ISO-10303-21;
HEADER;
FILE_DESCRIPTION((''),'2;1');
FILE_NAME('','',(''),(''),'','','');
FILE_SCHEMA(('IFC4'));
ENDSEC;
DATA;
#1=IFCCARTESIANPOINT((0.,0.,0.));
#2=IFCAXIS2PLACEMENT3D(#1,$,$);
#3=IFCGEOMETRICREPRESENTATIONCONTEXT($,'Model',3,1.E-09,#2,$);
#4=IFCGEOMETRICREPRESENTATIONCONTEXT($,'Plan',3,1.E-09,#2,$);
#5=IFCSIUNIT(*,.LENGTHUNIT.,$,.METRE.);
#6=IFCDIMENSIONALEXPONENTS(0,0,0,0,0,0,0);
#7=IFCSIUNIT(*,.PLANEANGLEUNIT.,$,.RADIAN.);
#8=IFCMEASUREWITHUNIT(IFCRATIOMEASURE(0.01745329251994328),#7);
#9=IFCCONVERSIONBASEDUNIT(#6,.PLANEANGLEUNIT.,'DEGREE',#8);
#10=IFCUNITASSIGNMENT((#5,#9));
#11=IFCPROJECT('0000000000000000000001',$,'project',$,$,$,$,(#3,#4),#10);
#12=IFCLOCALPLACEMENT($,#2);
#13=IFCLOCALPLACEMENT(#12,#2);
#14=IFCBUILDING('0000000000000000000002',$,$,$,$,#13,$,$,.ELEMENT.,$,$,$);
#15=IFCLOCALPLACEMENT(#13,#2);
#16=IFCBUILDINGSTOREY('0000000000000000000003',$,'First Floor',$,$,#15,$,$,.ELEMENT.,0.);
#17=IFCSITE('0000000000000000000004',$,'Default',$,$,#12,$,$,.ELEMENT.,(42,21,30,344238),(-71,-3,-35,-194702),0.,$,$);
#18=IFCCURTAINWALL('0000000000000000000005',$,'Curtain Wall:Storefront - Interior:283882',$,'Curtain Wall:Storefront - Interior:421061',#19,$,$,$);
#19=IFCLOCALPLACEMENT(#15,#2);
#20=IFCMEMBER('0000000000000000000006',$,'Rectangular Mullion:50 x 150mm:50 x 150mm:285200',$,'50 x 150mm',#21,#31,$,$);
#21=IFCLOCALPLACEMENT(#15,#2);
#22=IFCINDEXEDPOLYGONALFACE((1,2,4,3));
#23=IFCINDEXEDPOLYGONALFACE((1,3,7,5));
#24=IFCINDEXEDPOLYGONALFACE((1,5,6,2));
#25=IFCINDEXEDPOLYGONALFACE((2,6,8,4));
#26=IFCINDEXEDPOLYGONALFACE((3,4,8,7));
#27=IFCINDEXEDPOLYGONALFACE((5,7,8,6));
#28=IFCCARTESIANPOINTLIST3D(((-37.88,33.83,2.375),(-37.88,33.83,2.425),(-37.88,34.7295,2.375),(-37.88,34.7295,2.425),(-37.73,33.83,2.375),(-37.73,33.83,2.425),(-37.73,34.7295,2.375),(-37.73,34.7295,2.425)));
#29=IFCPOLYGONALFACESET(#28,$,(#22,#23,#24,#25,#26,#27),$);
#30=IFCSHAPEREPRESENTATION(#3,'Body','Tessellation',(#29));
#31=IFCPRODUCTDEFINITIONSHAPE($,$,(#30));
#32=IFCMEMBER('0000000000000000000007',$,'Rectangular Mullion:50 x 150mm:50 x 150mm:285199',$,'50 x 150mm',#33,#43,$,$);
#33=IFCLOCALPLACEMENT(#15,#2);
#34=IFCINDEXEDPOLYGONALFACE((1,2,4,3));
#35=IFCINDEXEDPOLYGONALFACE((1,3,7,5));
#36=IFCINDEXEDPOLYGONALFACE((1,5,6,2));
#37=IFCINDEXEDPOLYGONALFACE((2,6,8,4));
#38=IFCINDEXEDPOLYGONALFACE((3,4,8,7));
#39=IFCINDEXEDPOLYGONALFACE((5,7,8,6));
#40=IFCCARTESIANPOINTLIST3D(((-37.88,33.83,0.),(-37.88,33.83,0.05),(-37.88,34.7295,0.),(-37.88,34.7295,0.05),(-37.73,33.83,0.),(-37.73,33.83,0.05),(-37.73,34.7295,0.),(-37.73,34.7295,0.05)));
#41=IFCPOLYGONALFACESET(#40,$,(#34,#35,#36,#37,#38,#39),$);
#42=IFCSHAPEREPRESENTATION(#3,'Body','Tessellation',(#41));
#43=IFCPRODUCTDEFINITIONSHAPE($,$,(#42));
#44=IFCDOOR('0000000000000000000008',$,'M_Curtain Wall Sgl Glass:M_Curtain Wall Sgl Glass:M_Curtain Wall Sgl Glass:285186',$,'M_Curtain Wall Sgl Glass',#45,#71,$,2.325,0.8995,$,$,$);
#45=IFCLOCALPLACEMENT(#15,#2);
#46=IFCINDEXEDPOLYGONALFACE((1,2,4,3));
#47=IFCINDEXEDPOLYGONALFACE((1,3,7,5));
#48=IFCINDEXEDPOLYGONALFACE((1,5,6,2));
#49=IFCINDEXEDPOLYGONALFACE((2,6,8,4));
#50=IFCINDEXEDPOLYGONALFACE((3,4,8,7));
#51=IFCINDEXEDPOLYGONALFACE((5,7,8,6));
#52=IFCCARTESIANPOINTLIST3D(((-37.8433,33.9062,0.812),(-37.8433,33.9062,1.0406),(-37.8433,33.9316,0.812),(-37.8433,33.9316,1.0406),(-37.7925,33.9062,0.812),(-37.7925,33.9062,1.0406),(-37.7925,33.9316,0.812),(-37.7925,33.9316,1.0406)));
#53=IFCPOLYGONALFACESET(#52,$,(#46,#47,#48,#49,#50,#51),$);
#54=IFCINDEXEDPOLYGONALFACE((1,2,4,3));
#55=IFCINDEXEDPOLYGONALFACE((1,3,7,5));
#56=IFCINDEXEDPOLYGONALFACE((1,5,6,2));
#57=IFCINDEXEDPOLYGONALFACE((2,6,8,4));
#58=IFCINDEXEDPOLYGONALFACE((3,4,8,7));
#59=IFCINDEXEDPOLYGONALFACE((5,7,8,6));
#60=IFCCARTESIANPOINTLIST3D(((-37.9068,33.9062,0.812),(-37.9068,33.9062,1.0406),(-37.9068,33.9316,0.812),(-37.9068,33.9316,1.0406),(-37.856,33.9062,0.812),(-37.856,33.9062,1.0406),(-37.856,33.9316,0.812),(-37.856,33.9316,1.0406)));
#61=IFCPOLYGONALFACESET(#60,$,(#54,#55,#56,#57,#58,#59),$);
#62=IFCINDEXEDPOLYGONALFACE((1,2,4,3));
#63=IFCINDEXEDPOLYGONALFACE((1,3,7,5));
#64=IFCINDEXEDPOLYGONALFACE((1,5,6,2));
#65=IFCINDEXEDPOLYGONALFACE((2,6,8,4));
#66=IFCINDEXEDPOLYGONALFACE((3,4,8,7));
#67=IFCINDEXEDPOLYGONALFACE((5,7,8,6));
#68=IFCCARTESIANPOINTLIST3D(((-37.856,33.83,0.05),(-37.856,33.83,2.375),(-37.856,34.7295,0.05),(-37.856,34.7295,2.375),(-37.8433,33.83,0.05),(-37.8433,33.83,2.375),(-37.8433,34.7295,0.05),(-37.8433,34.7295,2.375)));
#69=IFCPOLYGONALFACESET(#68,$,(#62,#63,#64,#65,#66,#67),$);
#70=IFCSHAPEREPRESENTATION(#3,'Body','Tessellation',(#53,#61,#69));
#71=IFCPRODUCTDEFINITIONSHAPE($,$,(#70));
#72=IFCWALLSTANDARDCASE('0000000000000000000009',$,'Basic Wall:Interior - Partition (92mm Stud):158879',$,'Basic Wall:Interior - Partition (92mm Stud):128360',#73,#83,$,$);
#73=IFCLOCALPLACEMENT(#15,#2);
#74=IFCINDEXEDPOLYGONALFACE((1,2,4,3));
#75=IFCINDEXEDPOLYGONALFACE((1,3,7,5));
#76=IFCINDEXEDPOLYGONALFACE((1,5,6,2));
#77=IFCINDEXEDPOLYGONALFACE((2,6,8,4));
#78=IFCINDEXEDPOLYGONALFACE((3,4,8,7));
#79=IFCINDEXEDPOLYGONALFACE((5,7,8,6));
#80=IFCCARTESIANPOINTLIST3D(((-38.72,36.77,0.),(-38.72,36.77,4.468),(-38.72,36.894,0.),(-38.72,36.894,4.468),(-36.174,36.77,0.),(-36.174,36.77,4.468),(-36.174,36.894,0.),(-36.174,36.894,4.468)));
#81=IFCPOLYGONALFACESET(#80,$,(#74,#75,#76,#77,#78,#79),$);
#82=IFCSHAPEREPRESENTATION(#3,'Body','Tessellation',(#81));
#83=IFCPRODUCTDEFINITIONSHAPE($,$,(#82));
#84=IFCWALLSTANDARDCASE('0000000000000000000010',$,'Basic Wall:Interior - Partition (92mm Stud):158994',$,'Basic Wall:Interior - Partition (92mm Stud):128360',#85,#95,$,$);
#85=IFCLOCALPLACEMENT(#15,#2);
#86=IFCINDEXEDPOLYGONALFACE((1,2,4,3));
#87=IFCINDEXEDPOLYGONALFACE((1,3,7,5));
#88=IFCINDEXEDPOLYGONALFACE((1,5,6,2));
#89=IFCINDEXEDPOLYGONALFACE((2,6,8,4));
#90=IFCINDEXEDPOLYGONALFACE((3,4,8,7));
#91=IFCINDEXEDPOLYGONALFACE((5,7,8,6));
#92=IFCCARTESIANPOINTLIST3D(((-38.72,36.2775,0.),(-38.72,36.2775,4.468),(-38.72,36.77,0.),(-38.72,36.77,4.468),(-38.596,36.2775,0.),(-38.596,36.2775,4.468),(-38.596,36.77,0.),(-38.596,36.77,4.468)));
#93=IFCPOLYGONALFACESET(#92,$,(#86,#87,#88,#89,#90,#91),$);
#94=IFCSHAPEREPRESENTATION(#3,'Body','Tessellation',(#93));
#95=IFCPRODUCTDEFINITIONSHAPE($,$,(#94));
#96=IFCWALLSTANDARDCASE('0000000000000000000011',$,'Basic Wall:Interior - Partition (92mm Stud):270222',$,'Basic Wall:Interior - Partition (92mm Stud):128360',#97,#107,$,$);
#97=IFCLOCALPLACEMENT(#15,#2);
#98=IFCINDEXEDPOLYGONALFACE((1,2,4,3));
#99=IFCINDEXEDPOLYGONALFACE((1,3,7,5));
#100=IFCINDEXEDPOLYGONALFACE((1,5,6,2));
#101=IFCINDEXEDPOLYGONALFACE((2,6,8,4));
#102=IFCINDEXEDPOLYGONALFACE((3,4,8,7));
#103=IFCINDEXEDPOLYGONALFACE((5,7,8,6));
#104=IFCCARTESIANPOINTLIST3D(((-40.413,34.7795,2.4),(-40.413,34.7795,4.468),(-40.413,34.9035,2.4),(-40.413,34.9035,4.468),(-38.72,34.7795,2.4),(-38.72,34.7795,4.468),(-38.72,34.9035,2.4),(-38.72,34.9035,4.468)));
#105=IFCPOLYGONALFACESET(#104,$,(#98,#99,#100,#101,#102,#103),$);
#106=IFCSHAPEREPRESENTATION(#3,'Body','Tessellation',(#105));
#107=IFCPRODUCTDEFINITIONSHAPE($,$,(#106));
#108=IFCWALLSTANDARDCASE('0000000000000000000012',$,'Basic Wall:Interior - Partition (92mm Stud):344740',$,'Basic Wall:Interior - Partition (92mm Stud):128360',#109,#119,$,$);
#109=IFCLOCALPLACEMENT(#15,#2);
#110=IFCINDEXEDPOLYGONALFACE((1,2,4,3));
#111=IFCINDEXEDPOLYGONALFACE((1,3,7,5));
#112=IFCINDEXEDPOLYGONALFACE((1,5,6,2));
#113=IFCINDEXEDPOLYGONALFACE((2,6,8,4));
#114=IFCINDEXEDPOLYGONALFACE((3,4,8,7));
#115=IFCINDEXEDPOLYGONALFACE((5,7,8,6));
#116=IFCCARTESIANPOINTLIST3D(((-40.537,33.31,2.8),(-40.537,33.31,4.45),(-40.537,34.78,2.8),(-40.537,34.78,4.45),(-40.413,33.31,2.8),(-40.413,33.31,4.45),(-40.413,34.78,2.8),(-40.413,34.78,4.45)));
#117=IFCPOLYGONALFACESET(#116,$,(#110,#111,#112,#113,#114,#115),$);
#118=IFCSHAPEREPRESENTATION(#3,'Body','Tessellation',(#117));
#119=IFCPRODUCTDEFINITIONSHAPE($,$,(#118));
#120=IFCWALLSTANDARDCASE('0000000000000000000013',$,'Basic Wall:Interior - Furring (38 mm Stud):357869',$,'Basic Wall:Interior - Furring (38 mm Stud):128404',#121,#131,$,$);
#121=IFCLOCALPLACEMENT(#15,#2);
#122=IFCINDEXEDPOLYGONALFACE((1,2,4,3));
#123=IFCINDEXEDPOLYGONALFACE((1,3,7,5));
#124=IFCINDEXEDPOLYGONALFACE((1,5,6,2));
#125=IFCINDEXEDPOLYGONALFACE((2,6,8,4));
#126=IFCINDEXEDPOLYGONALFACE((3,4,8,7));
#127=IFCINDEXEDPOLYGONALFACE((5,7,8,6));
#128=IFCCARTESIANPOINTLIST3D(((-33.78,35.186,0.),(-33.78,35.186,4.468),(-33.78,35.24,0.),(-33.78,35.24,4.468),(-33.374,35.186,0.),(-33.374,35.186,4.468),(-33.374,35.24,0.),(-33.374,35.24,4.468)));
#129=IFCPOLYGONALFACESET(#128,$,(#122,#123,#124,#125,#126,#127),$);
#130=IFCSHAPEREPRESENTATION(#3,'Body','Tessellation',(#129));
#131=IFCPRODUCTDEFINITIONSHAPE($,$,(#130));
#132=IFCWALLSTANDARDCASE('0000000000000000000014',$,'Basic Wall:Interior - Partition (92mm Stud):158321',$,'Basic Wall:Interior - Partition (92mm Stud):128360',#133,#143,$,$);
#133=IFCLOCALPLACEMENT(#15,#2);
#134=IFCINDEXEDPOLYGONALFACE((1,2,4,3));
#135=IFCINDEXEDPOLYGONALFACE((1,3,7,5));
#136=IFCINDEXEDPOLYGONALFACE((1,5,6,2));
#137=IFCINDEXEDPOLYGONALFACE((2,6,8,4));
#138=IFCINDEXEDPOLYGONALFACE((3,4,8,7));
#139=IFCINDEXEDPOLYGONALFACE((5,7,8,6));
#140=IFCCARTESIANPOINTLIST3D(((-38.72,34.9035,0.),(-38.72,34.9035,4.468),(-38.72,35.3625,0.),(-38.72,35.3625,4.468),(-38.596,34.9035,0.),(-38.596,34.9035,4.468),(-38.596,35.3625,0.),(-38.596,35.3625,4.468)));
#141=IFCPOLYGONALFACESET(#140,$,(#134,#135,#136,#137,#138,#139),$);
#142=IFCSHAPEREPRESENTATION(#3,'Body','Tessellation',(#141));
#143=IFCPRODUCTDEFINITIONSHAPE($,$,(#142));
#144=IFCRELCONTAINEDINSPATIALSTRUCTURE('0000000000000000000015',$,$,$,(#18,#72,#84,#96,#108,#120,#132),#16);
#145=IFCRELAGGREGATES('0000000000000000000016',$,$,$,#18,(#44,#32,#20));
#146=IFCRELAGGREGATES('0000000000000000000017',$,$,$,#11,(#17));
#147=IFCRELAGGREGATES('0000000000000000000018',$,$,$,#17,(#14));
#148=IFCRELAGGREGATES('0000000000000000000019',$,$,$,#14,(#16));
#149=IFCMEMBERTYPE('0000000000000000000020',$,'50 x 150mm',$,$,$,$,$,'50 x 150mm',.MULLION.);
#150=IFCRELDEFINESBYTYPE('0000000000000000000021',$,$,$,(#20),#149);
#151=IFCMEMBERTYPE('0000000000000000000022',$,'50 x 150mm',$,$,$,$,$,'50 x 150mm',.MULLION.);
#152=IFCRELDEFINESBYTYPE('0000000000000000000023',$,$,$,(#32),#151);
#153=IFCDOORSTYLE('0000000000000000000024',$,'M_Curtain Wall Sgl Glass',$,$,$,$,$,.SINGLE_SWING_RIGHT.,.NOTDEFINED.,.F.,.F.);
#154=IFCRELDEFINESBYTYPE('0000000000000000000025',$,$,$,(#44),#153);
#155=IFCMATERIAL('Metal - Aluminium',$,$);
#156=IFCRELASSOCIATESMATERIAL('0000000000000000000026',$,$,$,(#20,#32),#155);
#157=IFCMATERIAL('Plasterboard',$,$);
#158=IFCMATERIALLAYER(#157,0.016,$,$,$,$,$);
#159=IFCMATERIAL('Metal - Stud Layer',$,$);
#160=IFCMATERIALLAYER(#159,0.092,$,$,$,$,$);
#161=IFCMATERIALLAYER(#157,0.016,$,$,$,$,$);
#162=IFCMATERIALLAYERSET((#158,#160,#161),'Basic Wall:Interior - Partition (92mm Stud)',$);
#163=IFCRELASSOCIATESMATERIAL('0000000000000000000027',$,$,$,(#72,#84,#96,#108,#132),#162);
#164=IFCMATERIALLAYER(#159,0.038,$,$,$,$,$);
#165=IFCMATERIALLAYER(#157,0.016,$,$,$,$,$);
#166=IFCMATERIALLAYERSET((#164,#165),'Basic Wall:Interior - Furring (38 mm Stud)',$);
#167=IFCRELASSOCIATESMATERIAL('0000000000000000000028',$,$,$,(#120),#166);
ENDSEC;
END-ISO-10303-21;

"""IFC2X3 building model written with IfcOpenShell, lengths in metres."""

from ifc_helpers import new_model, entity, si_unit, converted_unit, frame, frame_2d, origin, origin_2d_with_axis, place, context, project, spatial, rectangle, extrude, source, transform, mapped, material, layer, layer_set, layer_usage, type_object, type_shapes, element, aggregate, save


model = new_model("IFC2X3")

# Units and contexts
model_context = context("Model", 3, precision=1e-09, world=origin())
plan_context = context("Plan", 3, precision=1e-09, world=origin())
ifc_project = project(units=[si_unit("LENGTHUNIT", "METRE"), converted_unit("PLANEANGLEUNIT", "DEGREE", entity("IfcRatioMeasure", 0.01745329251994328), si_unit("PLANEANGLEUNIT", "RADIAN"), dimensions=[0, 0, 0, 0, 0, 0, 0])], contexts=[model_context, plan_context])

# Site, building, storey
site_placement = place(None, origin())
site = spatial("IfcSite", under=ifc_project, at=site_placement, Name="Default", CompositionType="ELEMENT", RefLatitude=(42, 21, 30, 344238), RefLongitude=(-71, -3, -35, -194702), RefElevation=0.0)
building_placement = place(site_placement, origin())
building = spatial("IfcBuilding", under=site, at=building_placement, CompositionType="ELEMENT")
storey_placement = place(building_placement, origin())
storey = spatial("IfcBuildingStorey", under=building, at=storey_placement, Name="First Floor", CompositionType="ELEMENT", Elevation=0.0)

# Shared definitions
ifc_material_1 = material(Name="Metal - Aluminium")

# Curtain wall
curtain_wall_1_placement = place(storey_placement, origin())
curtain_wall_1 = element("IfcCurtainWall", 1, at=curtain_wall_1_placement, inside=storey, Name="Curtain Wall:Storefront - Interior:283882", ObjectType="Curtain Wall:Storefront - Interior:421061")

# Members
member_type_1 = type_object("IfcMemberType", Name="50 x 150mm", ElementType="50 x 150mm", PredefinedType="MULLION")
shared_shape_1 = source(origin(), model_context, "Body", "SweptSolid", [
    extrude(rectangle(XDim=0.05, YDim=0.15, at=origin_2d_with_axis()), frame((0.0, 0.0, -0.8995), z_axis=(0.0, 0.0, 1.0), x_axis=(-1.0, 0.0, 0.0)), (0.0, 0.0, 1.0), 0.8995),
])
type_shapes(member_type_1, [shared_shape_1])
member_1_placement = place(storey_placement, frame((-37.805, 34.7295, 2.4), z_axis=(0.0, 1.0, 0.0), x_axis=(0.0, 0.0, 1.0)))
member_1 = element("IfcMember", 2, at=member_1_placement, type_object=member_type_1, material=ifc_material_1, Name="Rectangular Mullion:50 x 150mm:50 x 150mm:285200", ObjectType="50 x 150mm", context=model_context, shape_type="MappedRepresentation", body=[
    mapped(shared_shape_1, transform((0.0, 0.0, 0.0), scale=1.0)),
])
member_type_2 = type_object("IfcMemberType", Name="50 x 150mm", ElementType="50 x 150mm", PredefinedType="MULLION")
shared_shape_2 = source(origin(), model_context, "Body", "SweptSolid", [
    extrude(rectangle(XDim=0.05, YDim=0.15, at=origin_2d_with_axis()), frame((-0.025, 0.0, -0.8995), z_axis=(0.0, 0.0, 1.0), x_axis=(-1.0, 0.0, 0.0)), (0.0, 0.0, 1.0), 0.8995),
])
type_shapes(member_type_2, [shared_shape_2])
member_2_placement = place(storey_placement, frame((-37.805, 33.83, 0.0), z_axis=(0.0, -1.0, 0.0), x_axis=(0.0, 0.0, -1.0)))
member_2 = element("IfcMember", 3, at=member_2_placement, type_object=member_type_2, material=ifc_material_1, Name="Rectangular Mullion:50 x 150mm:50 x 150mm:285199", ObjectType="50 x 150mm", context=model_context, shape_type="MappedRepresentation", body=[
    mapped(shared_shape_2, transform((0.0, 0.0, 0.0), scale=1.0)),
])

# Door
door_style_1 = type_object("IfcDoorStyle", Name="M_Curtain Wall Sgl Glass", ConstructionType="NOTDEFINED", OperationType="SINGLE_SWING_RIGHT", ParameterTakesPrecedence=False, Sizeable=False)
shared_shape_3 = source(origin(), model_context, "Body", "SweptSolid", [
    extrude(rectangle(XDim=0.0508, YDim=0.0254, at=origin_2d_with_axis()), frame((-0.3609, 0.0129, 0.762), z_axis=(0.0, 0.0, 1.0), x_axis=(0.0, 1.0, 0.0)), (0.0, 0.0, 1.0), 0.2286),
    extrude(rectangle(XDim=0.0508, YDim=0.0254, at=origin_2d_with_axis()), frame((-0.3609, 0.0764, 0.762), z_axis=(0.0, 0.0, 1.0), x_axis=(0.0, -1.0, 0.0)), (0.0, 0.0, 1.0), 0.2286),
    extrude(rectangle(XDim=0.8995, YDim=0.0127, at=origin_2d_with_axis()), frame((0.0, 0.0447, 0.0), z_axis=(0.0, 0.0, 1.0), x_axis=(-1.0, 0.0, 0.0)), (0.0, 0.0, 1.0), 2.325),
])
type_shapes(door_style_1, [shared_shape_3])
door_1_placement = place(storey_placement, frame((-37.805, 34.2798, 0.05), z_axis=(0.0, 0.0, 1.0), x_axis=(0.0, 1.0, 0.0)))
door_1 = element("IfcDoor", 4, at=door_1_placement, type_object=door_style_1, Name="M_Curtain Wall Sgl Glass:M_Curtain Wall Sgl Glass:M_Curtain Wall Sgl Glass:285186", ObjectType="M_Curtain Wall Sgl Glass", OverallHeight=2.325, OverallWidth=0.8995, context=model_context, shape_type="MappedRepresentation", body=[
    mapped(shared_shape_3, transform((0.0, 0.0, 0.0), scale=1.0)),
])
aggregate(curtain_wall_1, [door_1, member_2, member_1])

# Walls
ifc_material_2 = material(Name="Plasterboard")
ifc_layer_1 = layer(ifc_material_2, 0.016)
ifc_material_3 = material(Name="Metal - Stud Layer")
ifc_layer_2 = layer(ifc_material_3, 0.092)
ifc_layer_3 = layer(ifc_material_2, 0.016)
ifc_layer_set_1 = layer_set([ifc_layer_1, ifc_layer_2, ifc_layer_3], Name="Basic Wall:Interior - Partition (92mm Stud)")
ifc_layer_usage_1 = layer_usage(ifc_layer_set_1, "AXIS2", "NEGATIVE", 0.062)
wall_1_placement = place(storey_placement, frame((-36.174, 36.832, 0.0), z_axis=(0.0, 0.0, 1.0), x_axis=(-1.0, 0.0, 0.0)))
element("IfcWallStandardCase", 5, at=wall_1_placement, inside=storey, material=ifc_layer_usage_1, Name="Basic Wall:Interior - Partition (92mm Stud):158879", ObjectType="Basic Wall:Interior - Partition (92mm Stud):128360", context=model_context, shape_type="SweptSolid", body=[
    extrude(rectangle(XDim=2.546, YDim=0.124, at=frame_2d((1.273, 0.0), x_axis=(-1.0, 0.0))), origin(), (0.0, 0.0, 1.0), 4.468),
])
wall_2_placement = place(storey_placement, frame((-38.658, 36.2775, 0.0), z_axis=(0.0, 0.0, 1.0), x_axis=(0.0, 1.0, 0.0)))
element("IfcWallStandardCase", 6, at=wall_2_placement, inside=storey, material=ifc_layer_usage_1, Name="Basic Wall:Interior - Partition (92mm Stud):158994", ObjectType="Basic Wall:Interior - Partition (92mm Stud):128360", context=model_context, shape_type="SweptSolid", body=[
    extrude(rectangle(XDim=0.4925, YDim=0.124, at=frame_2d((0.2463, 0.0), x_axis=(-1.0, 0.0))), origin(), (0.0, 0.0, 1.0), 4.468),
])
wall_3_placement = place(storey_placement, frame((-38.72, 34.8415, 2.4), z_axis=(0.0, 0.0, 1.0), x_axis=(-1.0, 0.0, 0.0)))
element("IfcWallStandardCase", 7, at=wall_3_placement, inside=storey, material=ifc_layer_usage_1, Name="Basic Wall:Interior - Partition (92mm Stud):270222", ObjectType="Basic Wall:Interior - Partition (92mm Stud):128360", context=model_context, shape_type="SweptSolid", body=[
    extrude(rectangle(XDim=1.693, YDim=0.124, at=frame_2d((0.8465, 0.0), x_axis=(-1.0, 0.0))), origin(), (0.0, 0.0, 1.0), 2.068),
])
wall_4_placement = place(storey_placement, frame((-40.475, 34.78, 2.8), z_axis=(0.0, 0.0, 1.0), x_axis=(0.0, -1.0, 0.0)))
element("IfcWallStandardCase", 8, at=wall_4_placement, inside=storey, material=ifc_layer_usage_1, Name="Basic Wall:Interior - Partition (92mm Stud):344740", ObjectType="Basic Wall:Interior - Partition (92mm Stud):128360", context=model_context, shape_type="SweptSolid", body=[
    extrude(rectangle(XDim=1.47, YDim=0.124, at=frame_2d((0.735, 0.0), x_axis=(-1.0, 0.0))), origin(), (0.0, 0.0, 1.0), 1.65),
])
ifc_layer_4 = layer(ifc_material_3, 0.038)
ifc_layer_5 = layer(ifc_material_2, 0.016)
ifc_layer_set_2 = layer_set([ifc_layer_4, ifc_layer_5], Name="Basic Wall:Interior - Furring (38 mm Stud)")
ifc_layer_usage_2 = layer_usage(ifc_layer_set_2, "AXIS2", "NEGATIVE", 0.027)
wall_5_placement = place(storey_placement, frame((-33.374, 35.213, 0.0), z_axis=(0.0, 0.0, 1.0), x_axis=(-1.0, 0.0, 0.0)))
element("IfcWallStandardCase", 9, at=wall_5_placement, inside=storey, material=ifc_layer_usage_2, Name="Basic Wall:Interior - Furring (38 mm Stud):357869", ObjectType="Basic Wall:Interior - Furring (38 mm Stud):128404", context=model_context, shape_type="SweptSolid", body=[
    extrude(rectangle(XDim=0.406, YDim=0.054, at=frame_2d((0.203, 0.0), x_axis=(-1.0, 0.0))), origin(), (0.0, 0.0, 1.0), 4.468),
])
wall_6_placement = place(storey_placement, frame((-38.658, 34.9035, 0.0), z_axis=(0.0, 0.0, 1.0), x_axis=(0.0, 1.0, 0.0)))
element("IfcWallStandardCase", 10, at=wall_6_placement, inside=storey, material=ifc_layer_usage_1, Name="Basic Wall:Interior - Partition (92mm Stud):158321", ObjectType="Basic Wall:Interior - Partition (92mm Stud):128360", context=model_context, shape_type="SweptSolid", body=[
    extrude(rectangle(XDim=0.459, YDim=0.124, at=frame_2d((0.2295, 0.0), x_axis=(-1.0, 0.0))), origin(), (0.0, 0.0, 1.0), 4.468),
])

save(model, "model.ifc")
